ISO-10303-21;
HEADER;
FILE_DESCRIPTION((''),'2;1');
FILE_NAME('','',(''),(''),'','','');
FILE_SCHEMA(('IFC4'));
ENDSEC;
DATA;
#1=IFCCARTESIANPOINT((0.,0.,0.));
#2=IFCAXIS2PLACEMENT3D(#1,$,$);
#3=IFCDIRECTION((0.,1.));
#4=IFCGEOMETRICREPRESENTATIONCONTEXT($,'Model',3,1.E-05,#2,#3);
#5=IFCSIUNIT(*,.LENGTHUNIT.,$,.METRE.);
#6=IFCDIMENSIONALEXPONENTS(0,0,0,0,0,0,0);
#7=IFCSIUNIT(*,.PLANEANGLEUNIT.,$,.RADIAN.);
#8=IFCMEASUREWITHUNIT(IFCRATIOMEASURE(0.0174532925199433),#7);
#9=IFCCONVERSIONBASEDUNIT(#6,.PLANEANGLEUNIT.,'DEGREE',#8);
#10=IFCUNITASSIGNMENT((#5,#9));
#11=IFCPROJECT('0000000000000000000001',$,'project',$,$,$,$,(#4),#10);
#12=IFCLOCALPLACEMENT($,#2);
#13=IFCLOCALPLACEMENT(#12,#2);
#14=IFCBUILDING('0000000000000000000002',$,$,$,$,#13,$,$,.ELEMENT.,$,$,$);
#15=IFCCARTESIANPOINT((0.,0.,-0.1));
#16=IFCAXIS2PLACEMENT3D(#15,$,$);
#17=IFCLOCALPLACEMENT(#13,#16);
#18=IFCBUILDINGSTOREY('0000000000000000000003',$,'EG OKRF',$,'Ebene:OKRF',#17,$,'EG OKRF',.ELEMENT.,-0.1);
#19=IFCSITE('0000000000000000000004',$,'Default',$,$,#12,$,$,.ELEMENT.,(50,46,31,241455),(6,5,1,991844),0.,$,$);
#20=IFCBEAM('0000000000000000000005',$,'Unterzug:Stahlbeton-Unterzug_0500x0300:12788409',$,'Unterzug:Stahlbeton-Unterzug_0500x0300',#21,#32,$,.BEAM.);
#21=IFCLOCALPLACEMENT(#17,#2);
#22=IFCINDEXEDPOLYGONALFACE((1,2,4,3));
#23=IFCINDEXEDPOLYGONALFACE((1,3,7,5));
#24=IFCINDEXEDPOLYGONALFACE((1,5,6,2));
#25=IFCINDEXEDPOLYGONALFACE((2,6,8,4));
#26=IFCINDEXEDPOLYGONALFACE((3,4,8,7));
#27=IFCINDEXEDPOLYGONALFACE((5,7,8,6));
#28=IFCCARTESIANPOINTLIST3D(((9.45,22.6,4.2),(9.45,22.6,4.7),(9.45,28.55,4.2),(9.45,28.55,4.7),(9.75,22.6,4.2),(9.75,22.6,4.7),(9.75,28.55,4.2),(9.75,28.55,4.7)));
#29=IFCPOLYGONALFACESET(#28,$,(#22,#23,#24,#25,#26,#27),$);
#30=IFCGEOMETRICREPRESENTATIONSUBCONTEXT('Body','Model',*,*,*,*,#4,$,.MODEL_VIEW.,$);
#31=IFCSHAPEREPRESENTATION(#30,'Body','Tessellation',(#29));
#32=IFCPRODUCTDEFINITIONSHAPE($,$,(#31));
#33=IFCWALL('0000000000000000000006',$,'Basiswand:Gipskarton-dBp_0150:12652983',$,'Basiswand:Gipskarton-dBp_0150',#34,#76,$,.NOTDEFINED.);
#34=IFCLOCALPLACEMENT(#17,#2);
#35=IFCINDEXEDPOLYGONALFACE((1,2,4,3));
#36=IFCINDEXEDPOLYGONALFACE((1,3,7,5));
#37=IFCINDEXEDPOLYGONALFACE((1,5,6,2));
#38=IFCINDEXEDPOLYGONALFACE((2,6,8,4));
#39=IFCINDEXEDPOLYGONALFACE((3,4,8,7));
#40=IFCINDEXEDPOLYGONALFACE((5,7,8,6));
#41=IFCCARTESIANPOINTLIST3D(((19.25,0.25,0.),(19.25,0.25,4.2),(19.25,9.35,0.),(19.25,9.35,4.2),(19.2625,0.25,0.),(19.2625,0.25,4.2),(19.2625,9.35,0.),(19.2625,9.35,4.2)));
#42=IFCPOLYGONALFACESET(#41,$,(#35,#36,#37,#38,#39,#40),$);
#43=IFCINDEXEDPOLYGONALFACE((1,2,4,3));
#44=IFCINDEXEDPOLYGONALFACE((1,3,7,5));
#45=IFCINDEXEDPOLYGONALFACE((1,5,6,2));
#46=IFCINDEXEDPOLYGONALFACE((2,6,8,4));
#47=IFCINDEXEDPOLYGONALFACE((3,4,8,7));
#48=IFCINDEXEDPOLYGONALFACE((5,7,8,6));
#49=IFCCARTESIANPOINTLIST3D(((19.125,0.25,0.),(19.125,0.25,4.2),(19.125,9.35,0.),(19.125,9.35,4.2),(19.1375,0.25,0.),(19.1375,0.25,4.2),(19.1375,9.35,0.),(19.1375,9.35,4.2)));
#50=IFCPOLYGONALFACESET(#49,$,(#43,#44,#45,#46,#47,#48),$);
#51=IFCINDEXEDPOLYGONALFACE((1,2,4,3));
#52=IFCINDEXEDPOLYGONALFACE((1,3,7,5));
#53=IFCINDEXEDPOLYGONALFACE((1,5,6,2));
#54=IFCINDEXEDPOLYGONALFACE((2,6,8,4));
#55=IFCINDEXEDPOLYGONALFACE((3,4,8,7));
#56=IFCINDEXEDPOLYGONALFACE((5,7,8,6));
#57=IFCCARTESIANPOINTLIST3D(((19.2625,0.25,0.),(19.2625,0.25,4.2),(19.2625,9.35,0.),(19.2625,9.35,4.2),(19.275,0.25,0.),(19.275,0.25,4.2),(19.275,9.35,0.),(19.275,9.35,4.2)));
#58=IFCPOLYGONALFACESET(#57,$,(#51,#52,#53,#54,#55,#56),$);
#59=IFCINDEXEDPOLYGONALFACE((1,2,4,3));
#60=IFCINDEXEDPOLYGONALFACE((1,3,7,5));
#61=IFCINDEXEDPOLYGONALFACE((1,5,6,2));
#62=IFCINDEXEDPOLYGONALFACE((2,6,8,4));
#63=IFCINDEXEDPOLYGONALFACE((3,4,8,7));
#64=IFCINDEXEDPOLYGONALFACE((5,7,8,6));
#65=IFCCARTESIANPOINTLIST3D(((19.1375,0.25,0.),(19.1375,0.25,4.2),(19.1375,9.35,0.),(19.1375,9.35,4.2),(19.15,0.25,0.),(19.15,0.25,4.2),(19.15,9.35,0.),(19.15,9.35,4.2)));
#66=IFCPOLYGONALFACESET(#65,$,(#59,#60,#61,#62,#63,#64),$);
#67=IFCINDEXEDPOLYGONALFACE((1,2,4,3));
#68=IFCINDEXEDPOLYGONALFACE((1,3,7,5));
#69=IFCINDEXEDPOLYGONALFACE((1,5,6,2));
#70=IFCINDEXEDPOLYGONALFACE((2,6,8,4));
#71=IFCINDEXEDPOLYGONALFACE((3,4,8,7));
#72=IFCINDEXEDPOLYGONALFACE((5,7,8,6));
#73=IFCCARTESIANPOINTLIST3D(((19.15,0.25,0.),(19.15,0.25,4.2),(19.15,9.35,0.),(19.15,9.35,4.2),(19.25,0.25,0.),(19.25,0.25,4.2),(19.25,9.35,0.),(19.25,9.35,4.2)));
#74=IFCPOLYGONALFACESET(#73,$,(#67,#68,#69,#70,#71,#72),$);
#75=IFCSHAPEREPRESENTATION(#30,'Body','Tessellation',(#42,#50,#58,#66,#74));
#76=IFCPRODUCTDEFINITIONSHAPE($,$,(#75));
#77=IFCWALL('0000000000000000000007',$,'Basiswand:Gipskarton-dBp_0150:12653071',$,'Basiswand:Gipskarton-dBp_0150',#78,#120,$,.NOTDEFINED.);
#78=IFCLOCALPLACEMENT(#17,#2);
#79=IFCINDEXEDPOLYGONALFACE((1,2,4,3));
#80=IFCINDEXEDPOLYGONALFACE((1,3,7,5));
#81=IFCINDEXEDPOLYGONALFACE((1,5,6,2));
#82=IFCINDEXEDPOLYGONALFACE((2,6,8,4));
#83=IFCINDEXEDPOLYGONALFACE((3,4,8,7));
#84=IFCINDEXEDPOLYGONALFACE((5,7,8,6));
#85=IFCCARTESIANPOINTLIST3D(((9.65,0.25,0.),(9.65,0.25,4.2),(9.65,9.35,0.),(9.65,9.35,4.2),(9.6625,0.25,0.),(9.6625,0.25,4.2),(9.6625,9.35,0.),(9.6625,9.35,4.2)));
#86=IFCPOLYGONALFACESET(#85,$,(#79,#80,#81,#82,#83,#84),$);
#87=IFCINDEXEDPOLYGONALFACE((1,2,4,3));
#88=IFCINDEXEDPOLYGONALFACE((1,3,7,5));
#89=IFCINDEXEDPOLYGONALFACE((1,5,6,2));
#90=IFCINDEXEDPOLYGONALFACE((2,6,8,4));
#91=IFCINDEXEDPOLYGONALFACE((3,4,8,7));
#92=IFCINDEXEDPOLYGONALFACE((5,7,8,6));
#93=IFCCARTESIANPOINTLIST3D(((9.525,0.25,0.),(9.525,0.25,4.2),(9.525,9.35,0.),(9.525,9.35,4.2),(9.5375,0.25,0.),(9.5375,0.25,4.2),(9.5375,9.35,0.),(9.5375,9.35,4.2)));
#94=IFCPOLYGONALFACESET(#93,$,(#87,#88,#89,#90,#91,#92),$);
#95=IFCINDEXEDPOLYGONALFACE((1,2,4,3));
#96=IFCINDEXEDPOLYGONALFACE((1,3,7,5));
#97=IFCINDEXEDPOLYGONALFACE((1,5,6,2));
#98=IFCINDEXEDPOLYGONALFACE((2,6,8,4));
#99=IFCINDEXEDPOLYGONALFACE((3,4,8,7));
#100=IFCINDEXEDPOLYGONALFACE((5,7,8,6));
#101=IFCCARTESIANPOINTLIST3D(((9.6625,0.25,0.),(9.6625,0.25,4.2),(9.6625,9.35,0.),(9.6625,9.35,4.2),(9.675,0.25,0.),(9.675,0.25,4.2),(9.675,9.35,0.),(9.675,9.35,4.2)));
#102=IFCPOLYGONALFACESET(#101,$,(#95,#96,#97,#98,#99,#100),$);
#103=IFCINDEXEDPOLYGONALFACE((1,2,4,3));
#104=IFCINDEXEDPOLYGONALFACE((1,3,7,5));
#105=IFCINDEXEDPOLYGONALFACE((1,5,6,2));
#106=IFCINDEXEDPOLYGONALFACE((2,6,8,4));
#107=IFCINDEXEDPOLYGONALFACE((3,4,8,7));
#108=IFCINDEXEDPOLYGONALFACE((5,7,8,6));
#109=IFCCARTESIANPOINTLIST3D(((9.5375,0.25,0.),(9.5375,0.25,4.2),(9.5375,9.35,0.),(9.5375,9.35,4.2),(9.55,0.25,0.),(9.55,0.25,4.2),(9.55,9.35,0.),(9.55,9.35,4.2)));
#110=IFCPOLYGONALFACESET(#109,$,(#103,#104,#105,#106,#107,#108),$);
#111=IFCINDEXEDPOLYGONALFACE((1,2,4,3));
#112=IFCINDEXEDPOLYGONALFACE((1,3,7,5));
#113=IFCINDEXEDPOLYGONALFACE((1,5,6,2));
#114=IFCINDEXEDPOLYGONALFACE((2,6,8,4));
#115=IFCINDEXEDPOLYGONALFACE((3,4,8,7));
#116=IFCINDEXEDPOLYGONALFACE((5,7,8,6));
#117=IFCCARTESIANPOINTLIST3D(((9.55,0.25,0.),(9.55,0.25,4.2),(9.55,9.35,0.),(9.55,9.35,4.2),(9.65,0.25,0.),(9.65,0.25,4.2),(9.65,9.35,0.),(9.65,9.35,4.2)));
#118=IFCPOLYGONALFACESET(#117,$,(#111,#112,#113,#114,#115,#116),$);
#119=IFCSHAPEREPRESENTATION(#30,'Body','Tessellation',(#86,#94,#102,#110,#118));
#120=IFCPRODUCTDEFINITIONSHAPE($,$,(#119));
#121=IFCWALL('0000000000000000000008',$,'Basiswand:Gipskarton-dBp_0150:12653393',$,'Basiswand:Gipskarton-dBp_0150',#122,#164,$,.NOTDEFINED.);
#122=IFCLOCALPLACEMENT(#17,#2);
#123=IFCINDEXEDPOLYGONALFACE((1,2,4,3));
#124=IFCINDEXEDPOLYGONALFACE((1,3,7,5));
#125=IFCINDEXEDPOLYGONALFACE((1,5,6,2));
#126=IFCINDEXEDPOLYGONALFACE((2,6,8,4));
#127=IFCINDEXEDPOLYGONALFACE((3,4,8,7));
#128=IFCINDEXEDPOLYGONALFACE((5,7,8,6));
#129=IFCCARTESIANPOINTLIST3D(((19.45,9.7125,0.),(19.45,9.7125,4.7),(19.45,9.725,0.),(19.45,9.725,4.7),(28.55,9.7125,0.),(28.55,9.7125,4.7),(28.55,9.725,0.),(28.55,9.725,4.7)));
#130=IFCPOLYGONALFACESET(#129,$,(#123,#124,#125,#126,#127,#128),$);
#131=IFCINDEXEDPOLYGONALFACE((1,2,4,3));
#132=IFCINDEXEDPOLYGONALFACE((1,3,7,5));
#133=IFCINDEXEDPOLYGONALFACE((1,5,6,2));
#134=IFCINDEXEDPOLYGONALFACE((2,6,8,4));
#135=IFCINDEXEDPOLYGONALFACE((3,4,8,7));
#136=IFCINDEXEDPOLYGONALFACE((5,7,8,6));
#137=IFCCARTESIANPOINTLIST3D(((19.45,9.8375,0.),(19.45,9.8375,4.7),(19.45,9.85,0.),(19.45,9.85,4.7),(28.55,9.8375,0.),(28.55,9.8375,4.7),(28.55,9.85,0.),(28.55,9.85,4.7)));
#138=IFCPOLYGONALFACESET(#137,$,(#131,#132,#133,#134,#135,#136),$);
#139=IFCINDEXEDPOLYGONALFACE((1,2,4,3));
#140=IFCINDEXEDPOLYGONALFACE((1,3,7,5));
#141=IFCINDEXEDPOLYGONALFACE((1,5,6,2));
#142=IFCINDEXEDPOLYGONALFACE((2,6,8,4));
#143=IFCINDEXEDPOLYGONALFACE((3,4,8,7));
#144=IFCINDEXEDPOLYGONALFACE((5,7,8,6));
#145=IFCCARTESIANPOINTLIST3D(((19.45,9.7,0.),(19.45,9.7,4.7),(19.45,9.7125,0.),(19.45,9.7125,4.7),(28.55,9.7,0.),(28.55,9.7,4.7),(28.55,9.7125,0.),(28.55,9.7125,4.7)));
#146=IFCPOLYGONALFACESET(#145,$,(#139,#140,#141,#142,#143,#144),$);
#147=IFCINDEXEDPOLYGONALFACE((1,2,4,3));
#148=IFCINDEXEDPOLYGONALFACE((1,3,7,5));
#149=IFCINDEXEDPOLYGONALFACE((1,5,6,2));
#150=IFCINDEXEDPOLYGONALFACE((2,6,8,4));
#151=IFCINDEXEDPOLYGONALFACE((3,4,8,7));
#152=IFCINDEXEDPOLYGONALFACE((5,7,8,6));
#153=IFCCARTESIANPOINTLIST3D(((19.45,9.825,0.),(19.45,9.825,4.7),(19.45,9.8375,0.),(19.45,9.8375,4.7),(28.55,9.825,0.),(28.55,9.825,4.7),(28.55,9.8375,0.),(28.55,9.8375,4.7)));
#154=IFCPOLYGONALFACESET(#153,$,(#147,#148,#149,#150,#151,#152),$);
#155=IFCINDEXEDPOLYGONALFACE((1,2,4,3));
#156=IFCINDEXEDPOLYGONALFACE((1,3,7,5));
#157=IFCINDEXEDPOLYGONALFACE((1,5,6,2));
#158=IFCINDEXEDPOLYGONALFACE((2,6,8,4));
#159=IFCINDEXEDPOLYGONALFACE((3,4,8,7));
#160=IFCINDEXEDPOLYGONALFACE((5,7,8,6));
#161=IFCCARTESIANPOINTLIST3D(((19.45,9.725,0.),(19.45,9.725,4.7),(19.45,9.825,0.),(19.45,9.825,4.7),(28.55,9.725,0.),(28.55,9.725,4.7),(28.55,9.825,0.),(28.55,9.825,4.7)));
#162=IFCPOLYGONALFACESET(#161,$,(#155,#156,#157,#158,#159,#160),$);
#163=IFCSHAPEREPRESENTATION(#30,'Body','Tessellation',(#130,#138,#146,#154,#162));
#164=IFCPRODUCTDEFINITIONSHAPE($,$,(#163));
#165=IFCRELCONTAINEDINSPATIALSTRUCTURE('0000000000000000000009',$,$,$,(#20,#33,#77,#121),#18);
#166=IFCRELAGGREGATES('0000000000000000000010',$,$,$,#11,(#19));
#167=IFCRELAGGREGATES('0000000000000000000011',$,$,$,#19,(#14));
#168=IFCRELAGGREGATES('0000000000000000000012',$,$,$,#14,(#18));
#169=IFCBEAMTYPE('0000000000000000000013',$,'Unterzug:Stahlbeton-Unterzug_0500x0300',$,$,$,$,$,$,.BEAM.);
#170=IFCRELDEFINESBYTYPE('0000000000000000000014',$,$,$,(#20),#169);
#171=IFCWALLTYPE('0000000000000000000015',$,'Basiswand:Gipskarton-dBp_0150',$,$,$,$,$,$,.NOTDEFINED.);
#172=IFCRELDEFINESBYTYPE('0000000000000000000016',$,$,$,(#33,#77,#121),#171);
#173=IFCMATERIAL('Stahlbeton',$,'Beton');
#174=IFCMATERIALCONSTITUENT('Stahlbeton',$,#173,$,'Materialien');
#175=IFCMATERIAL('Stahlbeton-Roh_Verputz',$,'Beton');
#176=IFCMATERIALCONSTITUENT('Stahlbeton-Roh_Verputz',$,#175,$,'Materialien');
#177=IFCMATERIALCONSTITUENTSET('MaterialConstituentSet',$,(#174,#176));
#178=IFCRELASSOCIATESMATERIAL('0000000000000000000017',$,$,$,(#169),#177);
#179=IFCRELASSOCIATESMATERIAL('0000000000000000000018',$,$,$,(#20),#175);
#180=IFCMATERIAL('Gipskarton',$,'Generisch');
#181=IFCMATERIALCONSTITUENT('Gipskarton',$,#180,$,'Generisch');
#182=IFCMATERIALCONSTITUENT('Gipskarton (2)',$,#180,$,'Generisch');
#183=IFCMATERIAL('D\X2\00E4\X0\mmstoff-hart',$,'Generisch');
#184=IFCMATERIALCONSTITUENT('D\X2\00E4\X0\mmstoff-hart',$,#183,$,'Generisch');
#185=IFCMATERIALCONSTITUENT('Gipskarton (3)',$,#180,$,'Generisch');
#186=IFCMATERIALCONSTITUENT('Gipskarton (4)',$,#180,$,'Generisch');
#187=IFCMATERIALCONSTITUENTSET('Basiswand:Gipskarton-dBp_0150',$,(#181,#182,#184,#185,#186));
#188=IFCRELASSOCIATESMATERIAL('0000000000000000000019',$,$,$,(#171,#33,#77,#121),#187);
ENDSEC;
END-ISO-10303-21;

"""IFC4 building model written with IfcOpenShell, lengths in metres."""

from ifc_helpers import new_model, entity, si_unit, converted_unit, direction, frame, origin, place, context, subcontext, project, spatial, indexed_curve, outline, extrude, source, transform, mapped, material, constituent, constituent_set, type_object, type_shapes, element, save


model = new_model("IFC4")

# Units and contexts
model_context = context("Model", 3, precision=1e-05, world=origin(), true_north=direction((0.0, 1.0)))
body_context = subcontext(model_context, "Body", "Model", "MODEL_VIEW")
ifc_project = project(units=[si_unit("LENGTHUNIT", "METRE"), converted_unit("PLANEANGLEUNIT", "DEGREE", entity("IfcRatioMeasure", 0.0174532925199433), si_unit("PLANEANGLEUNIT", "RADIAN"), dimensions=[0, 0, 0, 0, 0, 0, 0])], contexts=[model_context])

# Site, building, storey
site_placement = place(None, origin())
site = spatial("IfcSite", under=ifc_project, at=site_placement, Name="Default", CompositionType="ELEMENT", RefLatitude=(50, 46, 31, 241455), RefLongitude=(6, 5, 1, 991844), RefElevation=0.0)
building_placement = place(site_placement, origin())
building = spatial("IfcBuilding", under=site, at=building_placement, CompositionType="ELEMENT")
storey_placement = place(building_placement, frame((0.0, 0.0, -0.1)))
storey = spatial("IfcBuildingStorey", under=building, at=storey_placement, Name="EG OKRF", ObjectType="Ebene:OKRF", LongName="EG OKRF", CompositionType="ELEMENT", Elevation=-0.1)

# Shared definitions
ifc_material_1 = material(Name="Stahlbeton", Category="Beton")

# Beam
ifc_material_2 = material(Name="Stahlbeton-Roh_Verputz", Category="Beton")
ifc_constituent_1 = constituent(ifc_material_1, Name="Stahlbeton", Category="Materialien")
ifc_constituent_2 = constituent(ifc_material_2, Name="Stahlbeton-Roh_Verputz", Category="Materialien")
ifc_constituent_set_1 = constituent_set(constituents=[ifc_constituent_1, ifc_constituent_2], Name="MaterialConstituentSet")
beam_type_1 = type_object("IfcBeamType", Name="Unterzug:Stahlbeton-Unterzug_0500x0300", PredefinedType="BEAM", material=ifc_constituent_set_1)
shared_shape_1 = source(origin(), body_context, "Body", "SweptSolid", [
    extrude(outline(indexed_curve([(-0.15, -0.25), (0.15, -0.25), (0.15, 0.25), (-0.15, 0.25), (-0.15, -0.25)], self_intersect=False)), frame((9.6, 22.6, 4.35), z_axis=(0.0, 1.0, 0.0), x_axis=(-1.0, 0.0, 0.0)), (0.0, 0.0, 1.0), 5.95),
])
type_shapes(beam_type_1, [shared_shape_1])
beam_1_placement = place(storey_placement, frame((0.0, 0.0, 0.1)))
element("IfcBeam", 1, at=beam_1_placement, inside=storey, type_object=beam_type_1, material=ifc_material_2, Name="Unterzug:Stahlbeton-Unterzug_0500x0300:12788409", ObjectType="Unterzug:Stahlbeton-Unterzug_0500x0300", PredefinedType="BEAM", context=body_context, shape_type="MappedRepresentation", body=[
    mapped(shared_shape_1, transform((0.0, 0.0, 0.0), scale=1.0)),
])

# Shared definitions
ifc_material_3 = material(Name="Dämmstoff-hart", Category="Generisch")

# Walls
ifc_material_4 = material(Name="Gipskarton", Category="Generisch")
ifc_constituent_3 = constituent(ifc_material_4, Name="Gipskarton", Category="Generisch")
ifc_constituent_4 = constituent(ifc_material_4, Name="Gipskarton (2)", Category="Generisch")
ifc_constituent_5 = constituent(ifc_material_3, Name="Dämmstoff-hart", Category="Generisch")
ifc_constituent_6 = constituent(ifc_material_4, Name="Gipskarton (3)", Category="Generisch")
ifc_constituent_7 = constituent(ifc_material_4, Name="Gipskarton (4)", Category="Generisch")
ifc_constituent_set_2 = constituent_set(constituents=[ifc_constituent_3, ifc_constituent_4, ifc_constituent_5, ifc_constituent_6, ifc_constituent_7], Name="Basiswand:Gipskarton-dBp_0150")
wall_type_1 = type_object("IfcWallType", Name="Basiswand:Gipskarton-dBp_0150", PredefinedType="NOTDEFINED", material=ifc_constituent_set_2)
wall_1_placement = place(storey_placement, frame((19.2, 0.25, 0.0), z_axis=(0.0, 0.0, 1.0), x_axis=(0.0, 1.0, 0.0)))
element("IfcWall", 2, at=wall_1_placement, inside=storey, type_object=wall_type_1, material=ifc_constituent_set_2, Name="Basiswand:Gipskarton-dBp_0150:12652983", ObjectType="Basiswand:Gipskarton-dBp_0150", PredefinedType="NOTDEFINED", context=body_context, shape_type="SweptSolid", body=[
    extrude(outline(indexed_curve([(-4.55, -0.0063), (4.55, -0.0063), (4.55, 0.0062), (-4.55, 0.0062), (-4.55, -0.0063)], self_intersect=False)), frame((4.55, -0.0562, 0.0)), (0.0, 0.0, 1.0), 4.2),
    extrude(outline(indexed_curve([(-0.0062, -4.55), (0.0063, -4.55), (0.0062, 4.55), (-0.0063, 4.55), (-0.0062, -4.55)], self_intersect=False)), frame((4.55, 0.0688, 0.0), z_axis=(0.0, 0.0, 1.0), x_axis=(0.0, -1.0, 0.0)), (0.0, 0.0, 1.0), 4.2),
    extrude(outline(indexed_curve([(-0.0063, -4.55), (0.0062, -4.55), (0.0063, 4.55), (-0.0062, 4.55), (-0.0063, -4.55)], self_intersect=False)), frame((4.55, -0.0687, 0.0), z_axis=(0.0, 0.0, 1.0), x_axis=(0.0, 1.0, 0.0)), (0.0, 0.0, 1.0), 4.2),
    extrude(outline(indexed_curve([(-4.55, -0.0063), (4.55, -0.0063), (4.55, 0.0062), (-4.55, 0.0062), (-4.55, -0.0063)], self_intersect=False)), frame((4.55, 0.0563, 0.0)), (0.0, 0.0, 1.0), 4.2),
    extrude(outline(indexed_curve([(-4.55, -0.05), (4.55, -0.05), (4.55, 0.05), (-4.55, 0.05), (-4.55, -0.05)], self_intersect=False)), frame((4.55, 0.0, 0.0)), (0.0, 0.0, 1.0), 4.2),
])
wall_2_placement = place(storey_placement, frame((9.6, 0.25, 0.0), z_axis=(0.0, 0.0, 1.0), x_axis=(0.0, 1.0, 0.0)))
element("IfcWall", 3, at=wall_2_placement, inside=storey, type_object=wall_type_1, material=ifc_constituent_set_2, Name="Basiswand:Gipskarton-dBp_0150:12653071", ObjectType="Basiswand:Gipskarton-dBp_0150", PredefinedType="NOTDEFINED", context=body_context, shape_type="SweptSolid", body=[
    extrude(outline(indexed_curve([(-4.55, -0.0063), (4.55, -0.0063), (4.55, 0.0062), (-4.55, 0.0062), (-4.55, -0.0063)], self_intersect=False)), frame((4.55, -0.0562, 0.0)), (0.0, 0.0, 1.0), 4.2),
    extrude(outline(indexed_curve([(-0.0063, -4.55), (0.0062, -4.55), (0.0063, 4.55), (-0.0062, 4.55), (-0.0063, -4.55)], self_intersect=False)), frame((4.55, 0.0688, 0.0), z_axis=(0.0, 0.0, 1.0), x_axis=(0.0, -1.0, 0.0)), (0.0, 0.0, 1.0), 4.2),
    extrude(outline(indexed_curve([(-0.0063, -4.55), (0.0062, -4.55), (0.0063, 4.55), (-0.0062, 4.55), (-0.0063, -4.55)], self_intersect=False)), frame((4.55, -0.0688, 0.0), z_axis=(0.0, 0.0, 1.0), x_axis=(0.0, 1.0, 0.0)), (0.0, 0.0, 1.0), 4.2),
    extrude(outline(indexed_curve([(-4.55, -0.0063), (4.55, -0.0063), (4.55, 0.0062), (-4.55, 0.0062), (-4.55, -0.0063)], self_intersect=False)), frame((4.55, 0.0563, 0.0)), (0.0, 0.0, 1.0), 4.2),
    extrude(outline(indexed_curve([(-4.55, -0.05), (4.55, -0.05), (4.55, 0.05), (-4.55, 0.05), (-4.55, -0.05)], self_intersect=False)), frame((4.55, 0.0, 0.0)), (0.0, 0.0, 1.0), 4.2),
])
wall_3_placement = place(storey_placement, frame((19.45, 9.775, 0.0)))
element("IfcWall", 4, at=wall_3_placement, inside=storey, type_object=wall_type_1, material=ifc_constituent_set_2, Name="Basiswand:Gipskarton-dBp_0150:12653393", ObjectType="Basiswand:Gipskarton-dBp_0150", PredefinedType="NOTDEFINED", context=body_context, shape_type="SweptSolid", body=[
    extrude(outline(indexed_curve([(-4.55, -0.0063), (4.55, -0.0063), (4.55, 0.0062), (-4.55, 0.0062), (-4.55, -0.0063)], self_intersect=False)), frame((4.55, -0.0562, 0.0)), (0.0, 0.0, 1.0), 4.7),
    extrude(outline(indexed_curve([(-0.0063, -4.55), (0.0062, -4.55), (0.0063, 4.55), (-0.0062, 4.55), (-0.0063, -4.55)], self_intersect=False)), frame((4.55, 0.0688, 0.0), z_axis=(0.0, 0.0, 1.0), x_axis=(0.0, -1.0, 0.0)), (0.0, 0.0, 1.0), 4.7),
    extrude(outline(indexed_curve([(-0.0063, -4.55), (0.0062, -4.55), (0.0063, 4.55), (-0.0062, 4.55), (-0.0063, -4.55)], self_intersect=False)), frame((4.55, -0.0687, 0.0), z_axis=(0.0, 0.0, 1.0), x_axis=(0.0, 1.0, 0.0)), (0.0, 0.0, 1.0), 4.7),
    extrude(outline(indexed_curve([(-4.55, -0.0063), (4.55, -0.0063), (4.55, 0.0063), (-4.55, 0.0063), (-4.55, -0.0063)], self_intersect=False)), frame((4.55, 0.0563, 0.0)), (0.0, 0.0, 1.0), 4.7),
    extrude(outline(indexed_curve([(-4.55, -0.05), (4.55, -0.05), (4.55, 0.05), (-4.55, 0.05), (-4.55, -0.05)], self_intersect=False)), frame((4.55, 0.0, 0.0)), (0.0, 0.0, 1.0), 4.7),
])

save(model, "model.ifc")
